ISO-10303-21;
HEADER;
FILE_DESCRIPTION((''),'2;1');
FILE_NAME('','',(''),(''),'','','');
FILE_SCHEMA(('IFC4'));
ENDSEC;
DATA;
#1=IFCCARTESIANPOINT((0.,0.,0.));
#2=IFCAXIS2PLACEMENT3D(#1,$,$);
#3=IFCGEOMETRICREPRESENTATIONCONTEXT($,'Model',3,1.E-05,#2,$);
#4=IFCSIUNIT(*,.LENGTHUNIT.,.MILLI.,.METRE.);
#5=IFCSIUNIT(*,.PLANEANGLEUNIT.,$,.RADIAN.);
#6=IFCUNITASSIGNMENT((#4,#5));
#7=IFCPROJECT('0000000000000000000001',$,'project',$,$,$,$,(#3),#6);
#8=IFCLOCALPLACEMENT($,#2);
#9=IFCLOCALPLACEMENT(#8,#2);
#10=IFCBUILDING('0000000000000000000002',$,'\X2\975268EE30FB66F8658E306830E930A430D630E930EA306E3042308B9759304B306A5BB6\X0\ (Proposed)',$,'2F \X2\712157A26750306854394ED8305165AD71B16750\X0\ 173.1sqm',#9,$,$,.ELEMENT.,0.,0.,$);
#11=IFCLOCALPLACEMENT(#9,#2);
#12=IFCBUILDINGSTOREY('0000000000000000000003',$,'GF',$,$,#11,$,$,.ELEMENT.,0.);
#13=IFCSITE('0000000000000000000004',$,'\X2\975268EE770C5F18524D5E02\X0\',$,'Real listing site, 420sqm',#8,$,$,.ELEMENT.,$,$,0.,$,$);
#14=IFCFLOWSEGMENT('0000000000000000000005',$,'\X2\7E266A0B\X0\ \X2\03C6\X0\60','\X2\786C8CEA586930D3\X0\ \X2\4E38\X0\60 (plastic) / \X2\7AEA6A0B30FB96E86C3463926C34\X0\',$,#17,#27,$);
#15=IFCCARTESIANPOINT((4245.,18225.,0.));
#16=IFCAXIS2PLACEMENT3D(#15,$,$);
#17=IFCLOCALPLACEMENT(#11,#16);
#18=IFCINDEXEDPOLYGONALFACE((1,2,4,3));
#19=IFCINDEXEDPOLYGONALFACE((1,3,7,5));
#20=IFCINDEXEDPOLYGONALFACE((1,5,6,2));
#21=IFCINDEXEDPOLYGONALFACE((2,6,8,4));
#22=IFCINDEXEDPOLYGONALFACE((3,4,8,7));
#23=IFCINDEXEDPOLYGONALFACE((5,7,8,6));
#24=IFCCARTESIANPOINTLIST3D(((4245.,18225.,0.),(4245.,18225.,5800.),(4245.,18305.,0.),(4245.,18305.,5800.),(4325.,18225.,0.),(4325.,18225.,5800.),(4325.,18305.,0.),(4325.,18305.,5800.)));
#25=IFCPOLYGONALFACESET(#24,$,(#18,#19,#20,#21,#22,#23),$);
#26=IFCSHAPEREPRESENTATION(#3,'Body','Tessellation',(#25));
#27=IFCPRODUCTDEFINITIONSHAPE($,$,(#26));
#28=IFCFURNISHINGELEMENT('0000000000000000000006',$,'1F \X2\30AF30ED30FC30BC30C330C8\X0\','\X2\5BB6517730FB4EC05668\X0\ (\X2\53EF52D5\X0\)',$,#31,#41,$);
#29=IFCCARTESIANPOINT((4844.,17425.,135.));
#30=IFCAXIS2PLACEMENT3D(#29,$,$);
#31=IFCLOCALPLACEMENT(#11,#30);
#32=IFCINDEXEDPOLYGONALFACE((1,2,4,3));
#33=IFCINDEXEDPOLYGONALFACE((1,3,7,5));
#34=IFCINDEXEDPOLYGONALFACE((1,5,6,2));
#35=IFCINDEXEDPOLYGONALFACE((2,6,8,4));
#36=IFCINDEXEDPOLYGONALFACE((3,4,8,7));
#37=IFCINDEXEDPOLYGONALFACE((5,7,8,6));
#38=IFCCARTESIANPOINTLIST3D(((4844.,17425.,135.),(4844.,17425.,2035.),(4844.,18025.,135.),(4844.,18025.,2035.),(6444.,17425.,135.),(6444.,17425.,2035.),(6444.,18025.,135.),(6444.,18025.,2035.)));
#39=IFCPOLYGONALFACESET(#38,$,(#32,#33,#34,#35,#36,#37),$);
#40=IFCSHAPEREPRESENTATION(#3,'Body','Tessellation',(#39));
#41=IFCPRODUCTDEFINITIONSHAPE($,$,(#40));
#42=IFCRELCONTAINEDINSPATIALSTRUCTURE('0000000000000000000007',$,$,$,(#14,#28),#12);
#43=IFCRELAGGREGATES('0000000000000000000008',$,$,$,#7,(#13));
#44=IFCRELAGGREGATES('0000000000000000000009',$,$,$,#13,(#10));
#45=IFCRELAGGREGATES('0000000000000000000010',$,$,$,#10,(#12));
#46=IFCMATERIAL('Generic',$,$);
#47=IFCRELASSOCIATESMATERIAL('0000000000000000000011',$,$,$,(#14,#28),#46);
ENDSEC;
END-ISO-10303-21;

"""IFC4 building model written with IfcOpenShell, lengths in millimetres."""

from ifc_helpers import new_model, si_unit, frame, frame_2d, origin, place, context, project, spatial, rectangle, extrude, material, element, save


model = new_model("IFC4")

# Units and contexts
model_context = context("Model", 3, precision=1e-05, world=origin())
ifc_project = project(units=[si_unit("LENGTHUNIT", "METRE", prefix="MILLI"), si_unit("PLANEANGLEUNIT", "RADIAN")], contexts=[model_context])

# Site, building, storey
site_placement = place(None, origin())
site = spatial("IfcSite", under=ifc_project, at=site_placement, Name="青森県弘前市", ObjectType="Real listing site, 420sqm", CompositionType="ELEMENT", RefElevation=0.0)
building_placement = place(site_placement, origin())
building = spatial("IfcBuilding", under=site, at=building_placement, Name="青森・書斎とライブラリのある静かな家 (Proposed)", ObjectType="2F 無垢材と吹付け断熱材 173.1sqm", CompositionType="ELEMENT", ElevationOfRefHeight=0.0, ElevationOfTerrain=0.0)
storey_placement = place(building_placement, origin())
storey = spatial("IfcBuildingStorey", under=building, at=storey_placement, Name="GF", CompositionType="ELEMENT", Elevation=0.0)

# Shared definitions
ifc_material_1 = material(Name="Generic")

# Flow segment
flow_segment_placement = place(storey_placement, frame((4245.0, 18225.0, 0.0)))
element("IfcFlowSegment", 1, at=flow_segment_placement, inside=storey, material=ifc_material_1, Name="縦樋 φ60", Description="硬質塩ビ 丸60 (plastic) / 竪樋・雨水排水", context=model_context, shape_type="SweptSolid", body=[
    extrude(rectangle(XDim=80.0, YDim=80.0, at=frame_2d((40.0, 40.0))), frame((4245.0, 18225.0, 0.0)), (0.0, 0.0, 1.0), 5800.0),
])

# Furnishing element
furnishing_placement = place(storey_placement, frame((4844.0, 17425.0, 135.0)))
element("IfcFurnishingElement", 2, at=furnishing_placement, inside=storey, material=ifc_material_1, Name="1F クローゼット", Description="家具・什器 (可動)", context=model_context, shape_type="SweptSolid", body=[
    extrude(rectangle(XDim=1600.0, YDim=600.0, at=frame_2d((800.0, 300.0))), frame((4844.0, 17425.0, 135.0)), (0.0, 0.0, 1.0), 1900.0),
])

save(model, "model.ifc")
